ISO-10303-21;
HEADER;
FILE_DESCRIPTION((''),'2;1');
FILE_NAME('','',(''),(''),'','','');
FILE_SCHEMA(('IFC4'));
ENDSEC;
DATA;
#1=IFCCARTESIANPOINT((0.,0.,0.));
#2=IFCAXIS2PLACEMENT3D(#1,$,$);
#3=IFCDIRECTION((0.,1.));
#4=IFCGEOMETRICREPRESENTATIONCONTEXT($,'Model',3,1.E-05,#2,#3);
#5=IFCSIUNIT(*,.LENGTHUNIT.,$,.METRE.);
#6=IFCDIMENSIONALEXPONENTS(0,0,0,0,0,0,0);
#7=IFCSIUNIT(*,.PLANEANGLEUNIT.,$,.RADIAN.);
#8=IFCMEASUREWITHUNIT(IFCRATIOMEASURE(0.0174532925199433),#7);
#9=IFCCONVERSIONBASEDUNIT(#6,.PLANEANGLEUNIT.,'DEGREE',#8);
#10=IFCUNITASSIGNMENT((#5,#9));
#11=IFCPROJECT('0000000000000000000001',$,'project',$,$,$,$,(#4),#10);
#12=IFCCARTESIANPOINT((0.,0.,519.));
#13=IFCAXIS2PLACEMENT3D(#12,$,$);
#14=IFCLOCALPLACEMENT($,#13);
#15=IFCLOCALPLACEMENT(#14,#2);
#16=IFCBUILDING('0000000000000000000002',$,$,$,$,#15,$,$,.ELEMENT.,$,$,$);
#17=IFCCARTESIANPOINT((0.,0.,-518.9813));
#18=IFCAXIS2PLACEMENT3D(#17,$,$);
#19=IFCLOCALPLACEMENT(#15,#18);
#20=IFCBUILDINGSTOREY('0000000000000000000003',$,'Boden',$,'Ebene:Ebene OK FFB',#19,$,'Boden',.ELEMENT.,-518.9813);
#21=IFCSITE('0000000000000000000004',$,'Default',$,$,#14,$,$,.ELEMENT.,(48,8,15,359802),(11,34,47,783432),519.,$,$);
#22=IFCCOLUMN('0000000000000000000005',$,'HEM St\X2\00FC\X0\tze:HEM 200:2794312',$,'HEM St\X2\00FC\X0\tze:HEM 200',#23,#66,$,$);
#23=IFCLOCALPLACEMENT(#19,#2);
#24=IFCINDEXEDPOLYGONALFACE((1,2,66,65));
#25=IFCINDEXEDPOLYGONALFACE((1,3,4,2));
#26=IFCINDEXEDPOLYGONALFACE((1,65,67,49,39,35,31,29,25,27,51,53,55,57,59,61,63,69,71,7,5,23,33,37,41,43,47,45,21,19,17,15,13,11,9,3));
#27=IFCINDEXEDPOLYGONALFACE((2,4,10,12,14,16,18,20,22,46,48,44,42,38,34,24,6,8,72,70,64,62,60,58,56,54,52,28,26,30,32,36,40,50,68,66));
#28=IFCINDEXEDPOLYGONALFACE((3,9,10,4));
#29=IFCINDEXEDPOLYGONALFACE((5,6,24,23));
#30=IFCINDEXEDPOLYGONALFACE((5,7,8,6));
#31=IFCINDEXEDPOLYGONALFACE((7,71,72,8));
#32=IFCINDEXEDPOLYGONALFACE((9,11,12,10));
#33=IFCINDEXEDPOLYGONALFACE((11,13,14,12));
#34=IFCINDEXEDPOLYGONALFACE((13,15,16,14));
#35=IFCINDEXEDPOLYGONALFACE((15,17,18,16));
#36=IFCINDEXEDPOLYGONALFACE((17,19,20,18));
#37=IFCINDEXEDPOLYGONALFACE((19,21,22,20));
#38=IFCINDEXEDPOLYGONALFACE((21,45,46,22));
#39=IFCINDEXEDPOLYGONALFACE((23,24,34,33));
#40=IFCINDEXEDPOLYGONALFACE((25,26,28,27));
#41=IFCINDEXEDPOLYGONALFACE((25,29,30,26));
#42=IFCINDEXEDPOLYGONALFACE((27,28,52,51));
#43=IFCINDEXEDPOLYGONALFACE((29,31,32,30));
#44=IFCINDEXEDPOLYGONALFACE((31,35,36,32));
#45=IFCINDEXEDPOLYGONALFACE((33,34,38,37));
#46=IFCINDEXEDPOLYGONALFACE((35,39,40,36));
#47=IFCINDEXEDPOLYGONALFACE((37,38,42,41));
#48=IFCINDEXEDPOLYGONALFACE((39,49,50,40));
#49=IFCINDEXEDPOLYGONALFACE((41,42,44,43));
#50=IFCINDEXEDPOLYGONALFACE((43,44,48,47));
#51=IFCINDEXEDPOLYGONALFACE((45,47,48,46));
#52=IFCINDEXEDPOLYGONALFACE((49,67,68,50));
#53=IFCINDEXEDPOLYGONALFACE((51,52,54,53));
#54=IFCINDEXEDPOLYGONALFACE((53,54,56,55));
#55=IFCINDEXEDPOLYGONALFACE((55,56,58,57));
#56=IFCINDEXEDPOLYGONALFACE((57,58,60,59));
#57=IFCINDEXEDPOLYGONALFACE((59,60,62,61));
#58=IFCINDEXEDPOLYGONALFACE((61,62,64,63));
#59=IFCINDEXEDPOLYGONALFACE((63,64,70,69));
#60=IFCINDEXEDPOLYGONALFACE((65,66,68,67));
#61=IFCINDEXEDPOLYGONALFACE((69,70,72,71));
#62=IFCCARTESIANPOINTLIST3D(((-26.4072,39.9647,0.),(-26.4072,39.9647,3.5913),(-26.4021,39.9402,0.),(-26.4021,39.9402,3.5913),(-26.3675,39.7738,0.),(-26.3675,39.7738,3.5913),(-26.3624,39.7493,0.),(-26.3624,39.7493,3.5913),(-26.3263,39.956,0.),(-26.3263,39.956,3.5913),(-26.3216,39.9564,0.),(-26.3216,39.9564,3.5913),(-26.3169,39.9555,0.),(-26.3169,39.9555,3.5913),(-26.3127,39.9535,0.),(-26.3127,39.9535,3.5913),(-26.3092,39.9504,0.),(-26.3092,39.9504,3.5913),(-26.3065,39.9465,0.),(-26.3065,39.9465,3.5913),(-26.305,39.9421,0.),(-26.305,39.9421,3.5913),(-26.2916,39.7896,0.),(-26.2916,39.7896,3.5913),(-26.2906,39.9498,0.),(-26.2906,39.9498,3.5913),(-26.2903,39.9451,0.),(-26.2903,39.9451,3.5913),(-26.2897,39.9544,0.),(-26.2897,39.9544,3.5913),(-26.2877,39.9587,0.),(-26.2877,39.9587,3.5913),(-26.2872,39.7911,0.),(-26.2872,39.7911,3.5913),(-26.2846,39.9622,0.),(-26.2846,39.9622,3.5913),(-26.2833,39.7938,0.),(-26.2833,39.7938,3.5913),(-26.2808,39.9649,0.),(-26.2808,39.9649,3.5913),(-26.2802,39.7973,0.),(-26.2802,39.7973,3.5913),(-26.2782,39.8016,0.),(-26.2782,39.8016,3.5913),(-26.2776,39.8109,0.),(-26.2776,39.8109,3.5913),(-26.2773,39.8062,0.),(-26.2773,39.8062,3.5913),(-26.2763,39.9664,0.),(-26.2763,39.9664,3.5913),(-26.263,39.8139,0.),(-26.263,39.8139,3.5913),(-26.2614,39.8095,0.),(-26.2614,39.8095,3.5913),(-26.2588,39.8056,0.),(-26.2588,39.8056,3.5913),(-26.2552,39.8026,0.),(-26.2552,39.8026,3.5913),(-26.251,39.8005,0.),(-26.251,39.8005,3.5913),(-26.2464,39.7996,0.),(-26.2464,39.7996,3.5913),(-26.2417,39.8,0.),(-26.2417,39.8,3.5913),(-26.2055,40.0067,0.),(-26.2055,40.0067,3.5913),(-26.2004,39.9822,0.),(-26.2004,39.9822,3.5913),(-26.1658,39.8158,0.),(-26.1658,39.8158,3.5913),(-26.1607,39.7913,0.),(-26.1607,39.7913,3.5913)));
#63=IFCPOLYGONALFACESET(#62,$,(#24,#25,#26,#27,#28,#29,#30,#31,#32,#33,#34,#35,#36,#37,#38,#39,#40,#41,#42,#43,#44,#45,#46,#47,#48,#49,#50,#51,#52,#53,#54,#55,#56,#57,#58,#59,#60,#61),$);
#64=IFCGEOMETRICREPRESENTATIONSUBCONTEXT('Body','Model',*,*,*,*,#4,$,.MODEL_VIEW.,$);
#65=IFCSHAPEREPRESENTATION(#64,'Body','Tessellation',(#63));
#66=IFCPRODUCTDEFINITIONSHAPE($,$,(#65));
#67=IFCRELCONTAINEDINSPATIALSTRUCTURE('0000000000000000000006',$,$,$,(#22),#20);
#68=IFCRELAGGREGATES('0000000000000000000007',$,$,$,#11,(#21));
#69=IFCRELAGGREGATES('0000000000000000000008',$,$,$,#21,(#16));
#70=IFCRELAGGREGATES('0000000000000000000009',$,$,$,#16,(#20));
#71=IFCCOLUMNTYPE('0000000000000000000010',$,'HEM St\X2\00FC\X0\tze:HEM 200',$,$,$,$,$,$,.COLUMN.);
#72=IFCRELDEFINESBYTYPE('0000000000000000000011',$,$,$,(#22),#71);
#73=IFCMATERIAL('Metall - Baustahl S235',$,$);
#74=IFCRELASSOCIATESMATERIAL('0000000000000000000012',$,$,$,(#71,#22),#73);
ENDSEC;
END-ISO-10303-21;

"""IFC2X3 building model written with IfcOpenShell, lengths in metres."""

from ifc_helpers import new_model, entity, si_unit, converted_unit, direction, frame, frame_2d, origin, place, context, subcontext, project, spatial, polyline, circle_curve, parameter, trimmed, segment, composite_curve, outline, extrude, source, transform, mapped, material, type_object, type_shapes, element, save


model = new_model("IFC2X3")

# Units and contexts
model_context = context("Model", 3, precision=1e-05, world=origin(), true_north=direction((0.0, 1.0)))
body_context = subcontext(model_context, "Body", "Model", "MODEL_VIEW")
ifc_project = project(units=[si_unit("LENGTHUNIT", "METRE"), converted_unit("PLANEANGLEUNIT", "DEGREE", entity("IfcRatioMeasure", 0.0174532925199433), si_unit("PLANEANGLEUNIT", "RADIAN"), dimensions=[0, 0, 0, 0, 0, 0, 0])], contexts=[model_context])

# Site, building, storey
site_placement = place(None, frame((0.0, 0.0, 519.0)))
site = spatial("IfcSite", under=ifc_project, at=site_placement, Name="Default", CompositionType="ELEMENT", RefLatitude=(48, 8, 15, 359802), RefLongitude=(11, 34, 47, 783432), RefElevation=519.0)
building_placement = place(site_placement, origin())
building = spatial("IfcBuilding", under=site, at=building_placement, CompositionType="ELEMENT")
storey_placement = place(building_placement, frame((0.0, 0.0, -518.9813)))
storey = spatial("IfcBuildingStorey", under=building, at=storey_placement, Name="Boden", ObjectType="Ebene:Ebene OK FFB", LongName="Boden", CompositionType="ELEMENT", Elevation=-518.9813)

# Column
ifc_material = material(Name="Metall - Baustahl S235")
column_type_1 = type_object("IfcColumnType", Name="HEM Stütze:HEM 200", PredefinedType="COLUMN", material=ifc_material)
shared_shape_1 = source(origin(), body_context, "Body", "SweptSolid", [
    extrude(outline(composite_curve([segment(polyline([(0.085, -0.103), (0.11, -0.103)]), True, "CONTINUOUS"), segment(polyline([(0.11, -0.103), (0.11, 0.103)]), True, "CONTINUOUS"), segment(polyline([(0.11, 0.103), (0.085, 0.103)]), True, "CONTINUOUS"), segment(polyline([(0.085, 0.103), (0.085, 0.0255)]), True, "CONTINUOUS"), segment(trimmed(circle_curve(frame_2d((0.067, 0.0255), x_axis=(1.0, 0.0)), 0.018), [parameter(270.0)], [parameter(0.0)], True, "PARAMETER"), False, "CONTINUOUS"), segment(polyline([(0.067, 0.0075), (-0.067, 0.0075)]), True, "CONTINUOUS"), segment(trimmed(circle_curve(frame_2d((-0.067, 0.0255), x_axis=(0.0, -1.0)), 0.018), [parameter(270.0)], [parameter(0.0)], True, "PARAMETER"), False, "CONTINUOUS"), segment(polyline([(-0.085, 0.0255), (-0.085, 0.103)]), True, "CONTINUOUS"), segment(polyline([(-0.085, 0.103), (-0.11, 0.103)]), True, "CONTINUOUS"), segment(polyline([(-0.11, 0.103), (-0.11, -0.103)]), True, "CONTINUOUS"), segment(polyline([(-0.11, -0.103), (-0.085, -0.103)]), True, "CONTINUOUS"), segment(polyline([(-0.085, -0.103), (-0.085, -0.0255)]), True, "CONTINUOUS"), segment(trimmed(circle_curve(frame_2d((-0.067, -0.0255), x_axis=(-1.0, 0.0)), 0.018), [parameter(270.0)], [parameter(0.0)], True, "PARAMETER"), False, "CONTINUOUS"), segment(polyline([(-0.067, -0.0075), (0.067, -0.0075)]), True, "CONTINUOUS"), segment(trimmed(circle_curve(frame_2d((0.067, -0.0255), x_axis=(0.0, 1.0)), 0.018), [parameter(270.0)], [parameter(0.0)], True, "PARAMETER"), False, "CONTINUOUS"), segment(polyline([(0.085, -0.0255), (0.085, -0.103)]), True, "CONTINUOUS")], self_intersect=False)), frame((0.0, 0.0, -518.9813), z_axis=(0.0, 0.0, 1.0), x_axis=(0.0, -1.0, 0.0)), (0.0, 0.0, 1.0), 3.5913),
])
type_shapes(column_type_1, [shared_shape_1])
for number, where, z_axis, x_axis, name in (
    (1, (-26.284, 39.878, 518.9813), (0.0, 0.0, 1.0), (0.979008, 0.20382, 0.0), "HEM Stütze:HEM 200:2794312"),
):
    element("IfcColumn", number, at=place(storey_placement, frame(where, z_axis=z_axis, x_axis=x_axis)), inside=storey, type_object=column_type_1, material=ifc_material, Name=name, ObjectType="HEM Stütze:HEM 200", context=body_context, shape_type="MappedRepresentation", body=[
        mapped(shared_shape_1, transform((0.0, 0.0, 0.0), scale=1.0)),
    ])

save(model, "model.ifc")
